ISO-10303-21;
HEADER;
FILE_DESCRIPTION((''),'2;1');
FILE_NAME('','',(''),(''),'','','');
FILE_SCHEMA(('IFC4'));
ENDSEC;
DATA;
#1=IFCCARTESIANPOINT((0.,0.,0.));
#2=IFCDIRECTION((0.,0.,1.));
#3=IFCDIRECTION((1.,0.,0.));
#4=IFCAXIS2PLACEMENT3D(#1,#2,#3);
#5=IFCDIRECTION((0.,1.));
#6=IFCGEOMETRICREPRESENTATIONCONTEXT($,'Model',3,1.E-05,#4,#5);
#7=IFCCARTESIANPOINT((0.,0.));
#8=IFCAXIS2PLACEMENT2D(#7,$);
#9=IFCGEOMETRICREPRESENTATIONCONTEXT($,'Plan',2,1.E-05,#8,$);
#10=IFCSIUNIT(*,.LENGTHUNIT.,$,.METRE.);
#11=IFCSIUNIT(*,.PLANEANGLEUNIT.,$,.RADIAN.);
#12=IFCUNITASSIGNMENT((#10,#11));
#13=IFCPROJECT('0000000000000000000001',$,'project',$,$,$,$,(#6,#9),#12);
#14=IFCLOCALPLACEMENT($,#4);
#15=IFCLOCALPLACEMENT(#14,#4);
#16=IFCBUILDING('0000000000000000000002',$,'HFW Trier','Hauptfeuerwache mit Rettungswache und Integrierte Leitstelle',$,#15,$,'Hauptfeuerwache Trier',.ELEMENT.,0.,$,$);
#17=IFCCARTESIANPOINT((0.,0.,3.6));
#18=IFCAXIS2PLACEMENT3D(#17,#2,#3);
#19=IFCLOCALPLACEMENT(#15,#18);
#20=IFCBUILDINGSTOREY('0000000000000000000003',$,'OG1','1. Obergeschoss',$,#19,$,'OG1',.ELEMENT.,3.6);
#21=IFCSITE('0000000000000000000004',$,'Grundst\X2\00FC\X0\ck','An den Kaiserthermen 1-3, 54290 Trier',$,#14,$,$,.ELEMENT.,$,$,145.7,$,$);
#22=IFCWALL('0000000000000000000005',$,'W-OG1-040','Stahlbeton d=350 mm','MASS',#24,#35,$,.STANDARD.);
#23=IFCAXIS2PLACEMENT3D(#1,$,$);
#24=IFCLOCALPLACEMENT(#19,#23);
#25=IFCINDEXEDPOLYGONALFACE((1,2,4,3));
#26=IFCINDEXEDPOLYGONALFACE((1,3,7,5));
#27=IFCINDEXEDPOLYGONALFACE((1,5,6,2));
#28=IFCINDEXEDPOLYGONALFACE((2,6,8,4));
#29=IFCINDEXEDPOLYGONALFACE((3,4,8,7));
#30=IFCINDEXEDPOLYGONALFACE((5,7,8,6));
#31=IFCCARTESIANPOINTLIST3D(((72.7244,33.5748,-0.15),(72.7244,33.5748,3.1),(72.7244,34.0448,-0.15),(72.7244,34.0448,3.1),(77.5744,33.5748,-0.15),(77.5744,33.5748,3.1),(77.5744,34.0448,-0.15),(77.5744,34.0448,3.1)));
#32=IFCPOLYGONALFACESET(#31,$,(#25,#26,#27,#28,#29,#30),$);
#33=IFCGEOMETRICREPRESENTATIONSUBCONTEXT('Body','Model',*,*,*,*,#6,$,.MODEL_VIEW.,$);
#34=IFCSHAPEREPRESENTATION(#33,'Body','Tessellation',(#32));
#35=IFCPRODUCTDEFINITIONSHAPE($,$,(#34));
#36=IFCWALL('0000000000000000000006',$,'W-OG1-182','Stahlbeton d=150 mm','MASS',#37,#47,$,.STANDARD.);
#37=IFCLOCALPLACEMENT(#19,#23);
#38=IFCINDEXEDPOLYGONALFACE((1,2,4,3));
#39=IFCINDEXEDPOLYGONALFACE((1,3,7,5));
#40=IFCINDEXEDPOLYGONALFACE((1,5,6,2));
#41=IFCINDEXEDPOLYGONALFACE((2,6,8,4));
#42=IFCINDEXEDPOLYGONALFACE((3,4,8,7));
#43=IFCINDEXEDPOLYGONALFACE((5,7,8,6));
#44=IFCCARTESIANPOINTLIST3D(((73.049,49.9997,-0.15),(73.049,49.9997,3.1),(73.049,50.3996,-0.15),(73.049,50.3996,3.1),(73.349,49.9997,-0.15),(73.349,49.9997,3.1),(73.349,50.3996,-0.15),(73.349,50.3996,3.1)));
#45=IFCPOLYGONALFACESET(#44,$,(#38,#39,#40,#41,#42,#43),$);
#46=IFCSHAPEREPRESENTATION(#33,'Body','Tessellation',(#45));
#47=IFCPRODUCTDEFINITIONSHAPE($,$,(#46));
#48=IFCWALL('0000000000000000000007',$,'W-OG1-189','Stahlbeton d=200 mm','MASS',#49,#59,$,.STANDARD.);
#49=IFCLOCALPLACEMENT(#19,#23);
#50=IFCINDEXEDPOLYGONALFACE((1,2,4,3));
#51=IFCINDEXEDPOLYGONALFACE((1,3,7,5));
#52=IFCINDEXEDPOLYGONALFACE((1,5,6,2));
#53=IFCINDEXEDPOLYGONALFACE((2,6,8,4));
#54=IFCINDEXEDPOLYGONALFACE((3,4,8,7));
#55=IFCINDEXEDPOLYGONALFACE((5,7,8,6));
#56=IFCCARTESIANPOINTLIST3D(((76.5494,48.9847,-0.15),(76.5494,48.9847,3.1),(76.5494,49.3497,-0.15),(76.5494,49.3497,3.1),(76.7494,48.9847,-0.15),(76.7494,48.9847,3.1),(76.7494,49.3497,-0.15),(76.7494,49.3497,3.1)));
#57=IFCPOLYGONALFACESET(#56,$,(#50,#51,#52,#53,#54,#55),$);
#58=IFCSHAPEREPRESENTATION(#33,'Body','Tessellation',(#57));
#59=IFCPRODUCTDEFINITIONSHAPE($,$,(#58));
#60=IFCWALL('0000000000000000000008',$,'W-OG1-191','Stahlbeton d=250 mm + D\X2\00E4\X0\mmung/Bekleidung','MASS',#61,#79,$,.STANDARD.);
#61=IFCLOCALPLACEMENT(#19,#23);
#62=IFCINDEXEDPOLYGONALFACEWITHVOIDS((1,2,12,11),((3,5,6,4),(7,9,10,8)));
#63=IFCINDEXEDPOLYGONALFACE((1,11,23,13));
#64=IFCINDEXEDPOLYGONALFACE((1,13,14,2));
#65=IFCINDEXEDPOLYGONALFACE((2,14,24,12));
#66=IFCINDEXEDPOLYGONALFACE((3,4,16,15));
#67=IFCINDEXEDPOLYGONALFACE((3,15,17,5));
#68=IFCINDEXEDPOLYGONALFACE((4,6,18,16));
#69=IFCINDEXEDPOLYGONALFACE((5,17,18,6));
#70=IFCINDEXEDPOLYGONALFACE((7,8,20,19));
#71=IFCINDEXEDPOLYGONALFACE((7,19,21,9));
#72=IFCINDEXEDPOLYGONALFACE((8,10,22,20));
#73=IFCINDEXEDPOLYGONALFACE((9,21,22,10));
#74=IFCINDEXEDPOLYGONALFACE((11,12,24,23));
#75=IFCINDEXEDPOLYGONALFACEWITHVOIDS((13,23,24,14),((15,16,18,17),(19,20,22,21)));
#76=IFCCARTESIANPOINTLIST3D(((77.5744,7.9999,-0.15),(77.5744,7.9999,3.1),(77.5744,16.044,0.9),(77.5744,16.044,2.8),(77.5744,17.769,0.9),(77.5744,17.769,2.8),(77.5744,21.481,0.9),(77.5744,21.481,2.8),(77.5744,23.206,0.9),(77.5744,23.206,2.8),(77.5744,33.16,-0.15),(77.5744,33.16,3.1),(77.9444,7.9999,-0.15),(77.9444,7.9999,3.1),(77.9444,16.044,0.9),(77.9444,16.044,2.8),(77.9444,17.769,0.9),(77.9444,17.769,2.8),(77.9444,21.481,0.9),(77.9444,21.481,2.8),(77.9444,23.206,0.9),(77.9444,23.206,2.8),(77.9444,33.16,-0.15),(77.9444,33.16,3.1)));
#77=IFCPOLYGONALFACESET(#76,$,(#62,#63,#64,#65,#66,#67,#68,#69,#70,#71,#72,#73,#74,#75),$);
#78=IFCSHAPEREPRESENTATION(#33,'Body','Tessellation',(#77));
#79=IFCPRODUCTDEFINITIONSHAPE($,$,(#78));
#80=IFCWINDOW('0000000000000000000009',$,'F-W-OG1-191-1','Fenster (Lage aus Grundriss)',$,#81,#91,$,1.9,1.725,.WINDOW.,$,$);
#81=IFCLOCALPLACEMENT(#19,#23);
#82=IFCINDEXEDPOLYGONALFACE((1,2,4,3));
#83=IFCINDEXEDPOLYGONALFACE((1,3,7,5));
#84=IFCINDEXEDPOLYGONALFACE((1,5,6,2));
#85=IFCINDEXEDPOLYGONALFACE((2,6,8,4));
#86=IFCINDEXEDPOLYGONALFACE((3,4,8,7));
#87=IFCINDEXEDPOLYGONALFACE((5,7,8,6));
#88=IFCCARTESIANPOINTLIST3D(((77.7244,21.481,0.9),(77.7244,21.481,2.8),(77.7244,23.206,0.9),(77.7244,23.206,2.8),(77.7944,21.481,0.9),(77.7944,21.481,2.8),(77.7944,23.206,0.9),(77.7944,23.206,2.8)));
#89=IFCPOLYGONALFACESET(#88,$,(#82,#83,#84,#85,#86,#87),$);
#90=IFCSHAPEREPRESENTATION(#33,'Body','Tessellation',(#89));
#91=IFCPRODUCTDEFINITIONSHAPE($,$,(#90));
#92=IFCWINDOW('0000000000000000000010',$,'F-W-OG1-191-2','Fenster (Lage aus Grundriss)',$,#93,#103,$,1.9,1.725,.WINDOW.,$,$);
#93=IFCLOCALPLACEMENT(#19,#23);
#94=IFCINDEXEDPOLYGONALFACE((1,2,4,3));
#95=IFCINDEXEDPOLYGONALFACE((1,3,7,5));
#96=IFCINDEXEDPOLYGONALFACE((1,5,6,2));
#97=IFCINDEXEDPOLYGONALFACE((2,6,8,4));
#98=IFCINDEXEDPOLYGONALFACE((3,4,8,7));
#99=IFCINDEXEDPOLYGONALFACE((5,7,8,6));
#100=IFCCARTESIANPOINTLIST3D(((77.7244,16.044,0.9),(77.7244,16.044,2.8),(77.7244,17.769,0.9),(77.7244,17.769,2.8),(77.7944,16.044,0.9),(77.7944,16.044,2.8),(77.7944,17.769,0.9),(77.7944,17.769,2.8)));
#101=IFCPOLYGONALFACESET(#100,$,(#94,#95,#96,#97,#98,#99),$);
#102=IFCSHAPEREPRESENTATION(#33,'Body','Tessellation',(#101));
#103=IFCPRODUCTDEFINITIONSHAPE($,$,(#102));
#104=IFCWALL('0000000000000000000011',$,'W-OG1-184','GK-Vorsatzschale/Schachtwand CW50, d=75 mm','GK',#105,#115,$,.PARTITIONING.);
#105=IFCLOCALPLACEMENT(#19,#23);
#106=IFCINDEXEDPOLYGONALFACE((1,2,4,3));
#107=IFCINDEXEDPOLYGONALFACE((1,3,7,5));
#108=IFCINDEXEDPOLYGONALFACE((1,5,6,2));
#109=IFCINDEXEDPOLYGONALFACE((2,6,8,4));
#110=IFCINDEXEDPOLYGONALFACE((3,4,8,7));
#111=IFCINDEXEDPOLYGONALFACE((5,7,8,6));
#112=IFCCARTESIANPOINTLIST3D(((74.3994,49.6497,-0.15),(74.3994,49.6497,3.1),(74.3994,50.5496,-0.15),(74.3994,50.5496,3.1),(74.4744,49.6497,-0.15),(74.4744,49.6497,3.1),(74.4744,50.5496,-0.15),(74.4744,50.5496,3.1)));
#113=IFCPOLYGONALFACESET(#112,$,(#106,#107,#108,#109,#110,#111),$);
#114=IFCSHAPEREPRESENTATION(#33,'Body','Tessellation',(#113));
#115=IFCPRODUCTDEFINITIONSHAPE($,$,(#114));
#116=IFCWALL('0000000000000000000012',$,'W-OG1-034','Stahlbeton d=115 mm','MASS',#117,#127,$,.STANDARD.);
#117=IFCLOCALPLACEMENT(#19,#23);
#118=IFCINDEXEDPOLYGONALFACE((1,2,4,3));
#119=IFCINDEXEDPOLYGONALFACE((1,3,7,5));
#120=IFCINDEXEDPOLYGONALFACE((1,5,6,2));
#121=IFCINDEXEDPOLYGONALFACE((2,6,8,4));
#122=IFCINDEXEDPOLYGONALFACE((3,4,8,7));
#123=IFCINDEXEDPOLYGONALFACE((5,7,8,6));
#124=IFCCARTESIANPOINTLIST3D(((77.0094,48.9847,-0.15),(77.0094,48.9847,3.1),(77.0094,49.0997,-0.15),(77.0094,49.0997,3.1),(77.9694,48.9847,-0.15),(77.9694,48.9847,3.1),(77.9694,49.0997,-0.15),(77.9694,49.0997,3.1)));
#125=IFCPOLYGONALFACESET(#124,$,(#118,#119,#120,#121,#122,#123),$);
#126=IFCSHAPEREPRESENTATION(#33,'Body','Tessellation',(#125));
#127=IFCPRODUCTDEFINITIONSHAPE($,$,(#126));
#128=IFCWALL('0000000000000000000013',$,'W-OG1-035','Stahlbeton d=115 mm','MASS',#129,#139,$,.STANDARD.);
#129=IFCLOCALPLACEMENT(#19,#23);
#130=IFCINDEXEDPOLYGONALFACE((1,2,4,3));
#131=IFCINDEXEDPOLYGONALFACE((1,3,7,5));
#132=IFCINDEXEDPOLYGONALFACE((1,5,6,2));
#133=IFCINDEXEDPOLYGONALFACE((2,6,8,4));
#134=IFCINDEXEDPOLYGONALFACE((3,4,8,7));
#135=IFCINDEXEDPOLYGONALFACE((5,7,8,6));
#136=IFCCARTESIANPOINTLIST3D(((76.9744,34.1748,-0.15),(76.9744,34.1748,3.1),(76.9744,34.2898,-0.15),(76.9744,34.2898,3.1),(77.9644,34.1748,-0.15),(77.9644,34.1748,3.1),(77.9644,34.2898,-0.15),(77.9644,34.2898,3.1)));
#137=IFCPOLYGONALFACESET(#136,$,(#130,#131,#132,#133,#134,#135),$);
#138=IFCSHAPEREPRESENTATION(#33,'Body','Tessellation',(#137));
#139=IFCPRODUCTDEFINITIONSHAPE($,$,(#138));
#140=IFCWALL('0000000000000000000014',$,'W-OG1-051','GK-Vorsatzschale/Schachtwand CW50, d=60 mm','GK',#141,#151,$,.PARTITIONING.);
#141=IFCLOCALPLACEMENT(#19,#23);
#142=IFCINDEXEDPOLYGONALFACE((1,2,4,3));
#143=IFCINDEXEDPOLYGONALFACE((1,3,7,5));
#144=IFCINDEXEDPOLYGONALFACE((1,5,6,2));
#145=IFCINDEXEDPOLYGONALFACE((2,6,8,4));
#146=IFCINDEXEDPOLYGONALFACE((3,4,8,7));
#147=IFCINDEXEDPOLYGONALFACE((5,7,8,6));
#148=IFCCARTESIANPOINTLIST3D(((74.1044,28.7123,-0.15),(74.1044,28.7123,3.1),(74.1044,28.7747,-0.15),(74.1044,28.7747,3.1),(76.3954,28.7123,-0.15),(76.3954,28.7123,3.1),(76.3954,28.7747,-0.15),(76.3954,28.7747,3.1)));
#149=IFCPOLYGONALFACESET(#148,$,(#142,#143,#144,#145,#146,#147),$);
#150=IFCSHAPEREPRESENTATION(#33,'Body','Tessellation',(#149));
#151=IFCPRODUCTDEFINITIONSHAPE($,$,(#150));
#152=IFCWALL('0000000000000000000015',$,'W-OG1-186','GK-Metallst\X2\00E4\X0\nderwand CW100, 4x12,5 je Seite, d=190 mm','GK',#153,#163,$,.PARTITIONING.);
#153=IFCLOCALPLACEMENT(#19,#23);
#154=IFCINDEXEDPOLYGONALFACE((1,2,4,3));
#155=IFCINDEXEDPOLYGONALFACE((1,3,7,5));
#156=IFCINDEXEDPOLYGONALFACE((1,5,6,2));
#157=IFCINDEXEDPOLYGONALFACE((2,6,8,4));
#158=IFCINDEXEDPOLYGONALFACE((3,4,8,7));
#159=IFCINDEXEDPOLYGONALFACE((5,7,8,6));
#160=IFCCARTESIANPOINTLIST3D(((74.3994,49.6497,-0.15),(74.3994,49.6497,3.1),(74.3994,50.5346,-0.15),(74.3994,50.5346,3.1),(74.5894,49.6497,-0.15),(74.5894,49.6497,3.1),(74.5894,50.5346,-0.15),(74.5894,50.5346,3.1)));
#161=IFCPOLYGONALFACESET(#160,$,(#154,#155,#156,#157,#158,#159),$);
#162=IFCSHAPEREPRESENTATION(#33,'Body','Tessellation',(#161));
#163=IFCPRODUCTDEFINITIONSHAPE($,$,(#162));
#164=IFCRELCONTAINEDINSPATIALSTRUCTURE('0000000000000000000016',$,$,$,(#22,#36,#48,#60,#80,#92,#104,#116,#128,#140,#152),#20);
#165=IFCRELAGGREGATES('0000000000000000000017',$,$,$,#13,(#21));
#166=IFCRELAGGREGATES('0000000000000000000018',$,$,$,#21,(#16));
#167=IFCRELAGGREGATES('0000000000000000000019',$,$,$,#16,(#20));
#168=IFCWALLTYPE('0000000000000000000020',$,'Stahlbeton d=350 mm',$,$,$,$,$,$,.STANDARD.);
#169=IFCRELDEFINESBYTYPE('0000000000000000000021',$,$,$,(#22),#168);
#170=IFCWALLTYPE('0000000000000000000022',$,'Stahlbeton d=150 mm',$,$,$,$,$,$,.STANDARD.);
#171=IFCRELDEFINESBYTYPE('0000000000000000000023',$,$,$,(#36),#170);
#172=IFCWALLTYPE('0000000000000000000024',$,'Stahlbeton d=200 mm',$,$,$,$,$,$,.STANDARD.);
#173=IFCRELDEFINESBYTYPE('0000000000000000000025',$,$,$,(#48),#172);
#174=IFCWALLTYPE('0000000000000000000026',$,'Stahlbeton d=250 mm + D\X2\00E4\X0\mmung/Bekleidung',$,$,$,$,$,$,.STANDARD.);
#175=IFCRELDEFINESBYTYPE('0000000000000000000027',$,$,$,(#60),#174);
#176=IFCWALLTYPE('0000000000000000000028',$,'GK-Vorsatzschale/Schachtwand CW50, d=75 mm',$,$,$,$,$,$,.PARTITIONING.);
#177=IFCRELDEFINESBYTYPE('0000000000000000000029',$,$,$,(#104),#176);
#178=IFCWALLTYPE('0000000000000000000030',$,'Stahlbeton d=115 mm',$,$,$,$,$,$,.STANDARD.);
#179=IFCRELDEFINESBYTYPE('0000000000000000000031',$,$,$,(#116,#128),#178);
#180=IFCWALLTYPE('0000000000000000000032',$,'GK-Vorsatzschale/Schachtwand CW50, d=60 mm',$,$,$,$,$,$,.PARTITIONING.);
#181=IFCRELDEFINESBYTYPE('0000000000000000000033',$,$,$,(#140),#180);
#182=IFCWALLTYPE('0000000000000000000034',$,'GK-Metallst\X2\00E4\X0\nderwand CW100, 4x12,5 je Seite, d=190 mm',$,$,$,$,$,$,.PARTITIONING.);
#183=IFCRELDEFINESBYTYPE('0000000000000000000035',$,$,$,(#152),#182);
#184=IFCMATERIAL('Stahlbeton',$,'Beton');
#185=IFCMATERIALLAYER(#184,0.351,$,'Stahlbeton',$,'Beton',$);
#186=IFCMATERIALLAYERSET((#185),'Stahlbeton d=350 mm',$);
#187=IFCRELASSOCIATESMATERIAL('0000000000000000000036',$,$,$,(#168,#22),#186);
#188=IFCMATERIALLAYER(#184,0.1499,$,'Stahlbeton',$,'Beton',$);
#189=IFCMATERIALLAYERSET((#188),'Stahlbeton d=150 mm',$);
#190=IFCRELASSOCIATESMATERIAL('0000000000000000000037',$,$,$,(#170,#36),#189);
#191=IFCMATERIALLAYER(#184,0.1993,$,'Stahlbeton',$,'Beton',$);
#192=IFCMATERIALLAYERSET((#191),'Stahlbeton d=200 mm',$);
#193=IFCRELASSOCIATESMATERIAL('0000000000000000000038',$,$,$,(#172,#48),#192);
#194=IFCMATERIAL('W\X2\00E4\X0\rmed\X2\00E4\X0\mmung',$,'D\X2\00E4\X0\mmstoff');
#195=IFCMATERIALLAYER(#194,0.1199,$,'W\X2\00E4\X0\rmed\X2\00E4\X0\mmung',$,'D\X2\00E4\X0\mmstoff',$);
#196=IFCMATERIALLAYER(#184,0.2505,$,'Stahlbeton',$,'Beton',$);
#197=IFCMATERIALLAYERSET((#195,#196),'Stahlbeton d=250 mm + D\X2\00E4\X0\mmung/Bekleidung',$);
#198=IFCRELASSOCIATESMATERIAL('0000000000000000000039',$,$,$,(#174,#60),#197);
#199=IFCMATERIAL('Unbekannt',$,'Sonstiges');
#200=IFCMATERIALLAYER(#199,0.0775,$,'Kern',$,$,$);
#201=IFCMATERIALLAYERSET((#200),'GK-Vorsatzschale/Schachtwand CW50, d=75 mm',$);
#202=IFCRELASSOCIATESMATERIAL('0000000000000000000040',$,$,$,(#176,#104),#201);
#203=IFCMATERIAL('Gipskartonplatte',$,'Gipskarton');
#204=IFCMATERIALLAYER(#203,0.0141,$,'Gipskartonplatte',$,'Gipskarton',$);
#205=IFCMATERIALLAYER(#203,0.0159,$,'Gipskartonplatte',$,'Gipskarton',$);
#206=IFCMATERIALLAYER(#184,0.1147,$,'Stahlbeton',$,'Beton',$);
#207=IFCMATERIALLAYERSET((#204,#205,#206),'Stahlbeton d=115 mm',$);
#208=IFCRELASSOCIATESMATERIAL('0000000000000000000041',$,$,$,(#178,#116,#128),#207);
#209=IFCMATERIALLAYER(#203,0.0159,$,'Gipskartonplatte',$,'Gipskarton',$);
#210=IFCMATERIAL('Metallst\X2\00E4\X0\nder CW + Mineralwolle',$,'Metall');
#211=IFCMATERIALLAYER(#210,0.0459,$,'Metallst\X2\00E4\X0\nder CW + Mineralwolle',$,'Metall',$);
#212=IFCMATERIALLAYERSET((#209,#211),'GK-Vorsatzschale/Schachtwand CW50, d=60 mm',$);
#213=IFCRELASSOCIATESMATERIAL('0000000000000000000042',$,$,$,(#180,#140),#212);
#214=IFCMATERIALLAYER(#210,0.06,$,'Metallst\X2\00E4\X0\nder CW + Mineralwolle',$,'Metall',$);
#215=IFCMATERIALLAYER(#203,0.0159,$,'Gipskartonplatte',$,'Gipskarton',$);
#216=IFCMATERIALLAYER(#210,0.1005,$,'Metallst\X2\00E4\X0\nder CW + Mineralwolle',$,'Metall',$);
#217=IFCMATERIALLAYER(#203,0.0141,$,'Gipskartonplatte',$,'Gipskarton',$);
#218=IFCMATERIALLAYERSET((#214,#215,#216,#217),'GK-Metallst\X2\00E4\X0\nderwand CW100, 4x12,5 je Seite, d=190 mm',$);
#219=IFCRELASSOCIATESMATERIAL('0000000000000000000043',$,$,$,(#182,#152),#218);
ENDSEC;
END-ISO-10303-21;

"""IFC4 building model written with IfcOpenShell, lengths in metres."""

from ifc_helpers import new_model, si_unit, direction, frame, frame_2d, origin_with_axes, origin_2d, place, context, subcontext, project, spatial, rectangle, extrude, material, layer, layer_set, layer_usage, type_object, element, fill, save


model = new_model("IFC4")

# Units and contexts
model_context = context("Model", 3, precision=1e-05, world=origin_with_axes(), true_north=direction((0.0, 1.0)))
plan_context = context("Plan", 2, precision=1e-05, world=origin_2d())
body_context = subcontext(model_context, "Body", "Model", "MODEL_VIEW")
ifc_project = project(units=[si_unit("LENGTHUNIT", "METRE"), si_unit("PLANEANGLEUNIT", "RADIAN")], contexts=[model_context, plan_context])

# Site, building, storey
site_placement = place(None, origin_with_axes())
site = spatial("IfcSite", under=ifc_project, at=site_placement, Name="Grundstück", Description="An den Kaiserthermen 1-3, 54290 Trier", CompositionType="ELEMENT", RefElevation=145.7)
building_placement = place(site_placement, origin_with_axes())
building = spatial("IfcBuilding", under=site, at=building_placement, Name="HFW Trier", Description="Hauptfeuerwache mit Rettungswache und Integrierte Leitstelle", LongName="Hauptfeuerwache Trier", CompositionType="ELEMENT", ElevationOfRefHeight=0.0)
storey_placement = place(building_placement, frame((0.0, 0.0, 3.6), z_axis=(0.0, 0.0, 1.0), x_axis=(1.0, 0.0, 0.0)))
storey = spatial("IfcBuildingStorey", under=building, at=storey_placement, Name="OG1", Description="1. Obergeschoss", LongName="OG1", CompositionType="ELEMENT", Elevation=3.6)

# Shared definitions
ifc_material_1 = material(Name="Stahlbeton", Category="Beton")

# Shared definitions
ifc_material_2 = material(Name="Gipskartonplatte", Category="Gipskarton")
ifc_material_3 = material(Name="Metallständer CW + Mineralwolle", Category="Metall")

# Walls
ifc_layer_1 = layer(ifc_material_1, 0.351, Name="Stahlbeton", Category="Beton")
ifc_layer_set_1 = layer_set([ifc_layer_1], Name="Stahlbeton d=350 mm")
ifc_layer_usage_1 = layer_usage(ifc_layer_set_1, "AXIS2", "POSITIVE", -0.235)
wall_type_1 = type_object("IfcWallType", Name="Stahlbeton d=350 mm", PredefinedType="STANDARD", material=ifc_layer_set_1)
wall_1_placement = place(storey_placement, frame((72.7244, 33.8098, -0.15), z_axis=(0.0, 0.0, 1.0), x_axis=(1.0, 0.0, 0.0)))
element("IfcWall", 1, at=wall_1_placement, inside=storey, type_object=wall_type_1, material=ifc_layer_usage_1, Name="W-OG1-040", Description="Stahlbeton d=350 mm", ObjectType="MASS", PredefinedType="STANDARD", context=body_context, shape_type="SweptSolid", body=[
    extrude(rectangle(XDim=4.85, YDim=0.47, at=frame_2d((2.425, 0.0))), origin_with_axes(), (0.0, 0.0, 1.0), 3.25),
])
ifc_layer_2 = layer(ifc_material_1, 0.1499, Name="Stahlbeton", Category="Beton")
ifc_layer_set_2 = layer_set([ifc_layer_2], Name="Stahlbeton d=150 mm")
ifc_layer_usage_2 = layer_usage(ifc_layer_set_2, "AXIS2", "POSITIVE", -0.15)
wall_type_2 = type_object("IfcWallType", Name="Stahlbeton d=150 mm", PredefinedType="STANDARD", material=ifc_layer_set_2)
wall_2_placement = place(storey_placement, frame((73.199, 50.3996, -0.15), z_axis=(0.0, 0.0, 1.0), x_axis=(0.0, -1.0, 0.0)))
element("IfcWall", 2, at=wall_2_placement, inside=storey, type_object=wall_type_2, material=ifc_layer_usage_2, Name="W-OG1-182", Description="Stahlbeton d=150 mm", ObjectType="MASS", PredefinedType="STANDARD", context=body_context, shape_type="SweptSolid", body=[
    extrude(rectangle(XDim=0.3999, YDim=0.3, at=frame_2d((0.2, 0.0))), origin_with_axes(), (0.0, 0.0, 1.0), 3.25),
])
ifc_layer_3 = layer(ifc_material_1, 0.1993, Name="Stahlbeton", Category="Beton")
ifc_layer_set_3 = layer_set([ifc_layer_3], Name="Stahlbeton d=200 mm")
ifc_layer_usage_3 = layer_usage(ifc_layer_set_3, "AXIS2", "POSITIVE", -0.1)
wall_type_3 = type_object("IfcWallType", Name="Stahlbeton d=200 mm", PredefinedType="STANDARD", material=ifc_layer_set_3)
wall_3_placement = place(storey_placement, frame((76.6494, 49.3497, -0.15), z_axis=(0.0, 0.0, 1.0), x_axis=(0.0, -1.0, 0.0)))
element("IfcWall", 3, at=wall_3_placement, inside=storey, type_object=wall_type_3, material=ifc_layer_usage_3, Name="W-OG1-189", Description="Stahlbeton d=200 mm", ObjectType="MASS", PredefinedType="STANDARD", context=body_context, shape_type="SweptSolid", body=[
    extrude(rectangle(XDim=0.365, YDim=0.2, at=frame_2d((0.1825, 0.0))), origin_with_axes(), (0.0, 0.0, 1.0), 3.25),
])

# Wall, openings, windows
ifc_material_4 = material(Name="Wärmedämmung", Category="Dämmstoff")
ifc_layer_4 = layer(ifc_material_4, 0.1199, Name="Wärmedämmung", Category="Dämmstoff")
ifc_layer_5 = layer(ifc_material_1, 0.2505, Name="Stahlbeton", Category="Beton")
ifc_layer_set_4 = layer_set([ifc_layer_4, ifc_layer_5], Name="Stahlbeton d=250 mm + Dämmung/Bekleidung")
ifc_layer_usage_4 = layer_usage(ifc_layer_set_4, "AXIS2", "POSITIVE", -0.185)
wall_type_4 = type_object("IfcWallType", Name="Stahlbeton d=250 mm + Dämmung/Bekleidung", PredefinedType="STANDARD", material=ifc_layer_set_4)
wall_4_placement = place(storey_placement, frame((77.7594, 33.16, -0.15), z_axis=(0.0, 0.0, 1.0), x_axis=(0.0, -1.0, 0.0)))
wall_4 = element("IfcWall", 4, at=wall_4_placement, inside=storey, type_object=wall_type_4, material=ifc_layer_usage_4, Name="W-OG1-191", Description="Stahlbeton d=250 mm + Dämmung/Bekleidung", ObjectType="MASS", PredefinedType="STANDARD", context=body_context, shape_type="SweptSolid", body=[
    extrude(rectangle(XDim=25.1601, YDim=0.37, at=frame_2d((12.58, 0.0))), origin_with_axes(), (0.0, 0.0, 1.0), 3.25),
])
opening_1_placement = place(wall_4_placement, frame((9.954, 0.0, 0.0), z_axis=(0.0, 0.0, 1.0), x_axis=(1.0, 0.0, 0.0)))
opening_1 = element("IfcOpeningElement", 5, at=opening_1_placement, cuts=wall_4, PredefinedType="OPENING", context=body_context, shape_type="SweptSolid", body=[
    extrude(rectangle(XDim=1.725, YDim=0.47, at=frame_2d((0.8625, 0.0))), frame((0.0, 0.0, 1.05), z_axis=(0.0, 0.0, 1.0), x_axis=(1.0, 0.0, 0.0)), (0.0, 0.0, 1.0), 1.9),
])
opening_2_placement = place(wall_4_placement, frame((15.391, 0.0, 0.0), z_axis=(0.0, 0.0, 1.0), x_axis=(1.0, 0.0, 0.0)))
opening_2 = element("IfcOpeningElement", 6, at=opening_2_placement, cuts=wall_4, PredefinedType="OPENING", context=body_context, shape_type="SweptSolid", body=[
    extrude(rectangle(XDim=1.725, YDim=0.47, at=frame_2d((0.8625, 0.0))), frame((0.0, 0.0, 1.05), z_axis=(0.0, 0.0, 1.0), x_axis=(1.0, 0.0, 0.0)), (0.0, 0.0, 1.0), 1.9),
])
window_1_placement = place(wall_4_placement, frame((9.954, 0.0, 0.0), z_axis=(0.0, 0.0, 1.0), x_axis=(1.0, 0.0, 0.0)))
window_1 = element("IfcWindow", 7, at=window_1_placement, inside=storey, Name="F-W-OG1-191-1", Description="Fenster (Lage aus Grundriss)", OverallHeight=1.9, OverallWidth=1.725, PredefinedType="WINDOW", context=body_context, shape_type="SweptSolid", body=[
    extrude(rectangle(XDim=1.725, YDim=0.07, at=frame_2d((0.8625, 0.0))), frame((0.0, 0.0, 1.05), z_axis=(0.0, 0.0, 1.0), x_axis=(1.0, 0.0, 0.0)), (0.0, 0.0, 1.0), 1.9),
])
fill(opening_1, window_1)
window_2_placement = place(wall_4_placement, frame((15.391, 0.0, 0.0), z_axis=(0.0, 0.0, 1.0), x_axis=(1.0, 0.0, 0.0)))
window_2 = element("IfcWindow", 8, at=window_2_placement, inside=storey, Name="F-W-OG1-191-2", Description="Fenster (Lage aus Grundriss)", OverallHeight=1.9, OverallWidth=1.725, PredefinedType="WINDOW", context=body_context, shape_type="SweptSolid", body=[
    extrude(rectangle(XDim=1.725, YDim=0.07, at=frame_2d((0.8625, 0.0))), frame((0.0, 0.0, 1.05), z_axis=(0.0, 0.0, 1.0), x_axis=(1.0, 0.0, 0.0)), (0.0, 0.0, 1.0), 1.9),
])
fill(opening_2, window_2)

# Walls
ifc_material_5 = material(Name="Unbekannt", Category="Sonstiges")
ifc_layer_6 = layer(ifc_material_5, 0.0775, Name="Kern")
ifc_layer_set_5 = layer_set([ifc_layer_6], Name="GK-Vorsatzschale/Schachtwand CW50, d=75 mm")
ifc_layer_usage_5 = layer_usage(ifc_layer_set_5, "AXIS2", "POSITIVE", -0.0375)
wall_type_5 = type_object("IfcWallType", Name="GK-Vorsatzschale/Schachtwand CW50, d=75 mm", PredefinedType="PARTITIONING", material=ifc_layer_set_5)
wall_5_placement = place(storey_placement, frame((74.4369, 50.5496, -0.15), z_axis=(0.0, 0.0, 1.0), x_axis=(0.0, -1.0, 0.0)))
element("IfcWall", 9, at=wall_5_placement, inside=storey, type_object=wall_type_5, material=ifc_layer_usage_5, Name="W-OG1-184", Description="GK-Vorsatzschale/Schachtwand CW50, d=75 mm", ObjectType="GK", PredefinedType="PARTITIONING", context=body_context, shape_type="SweptSolid", body=[
    extrude(rectangle(XDim=0.8999, YDim=0.075, at=frame_2d((0.4499, 0.0))), origin_with_axes(), (0.0, 0.0, 1.0), 3.25),
])
ifc_layer_7 = layer(ifc_material_2, 0.0141, Name="Gipskartonplatte", Category="Gipskarton")
ifc_layer_8 = layer(ifc_material_2, 0.0159, Name="Gipskartonplatte", Category="Gipskarton")
ifc_layer_9 = layer(ifc_material_1, 0.1147, Name="Stahlbeton", Category="Beton")
ifc_layer_set_6 = layer_set([ifc_layer_7, ifc_layer_8, ifc_layer_9], Name="Stahlbeton d=115 mm")
ifc_layer_usage_6 = layer_usage(ifc_layer_set_6, "AXIS2", "POSITIVE", -0.0575)
wall_type_6 = type_object("IfcWallType", Name="Stahlbeton d=115 mm", PredefinedType="STANDARD", material=ifc_layer_set_6)
wall_6_placement = place(storey_placement, frame((77.0094, 49.0422, -0.15), z_axis=(0.0, 0.0, 1.0), x_axis=(1.0, 0.0, 0.0)))
element("IfcWall", 10, at=wall_6_placement, inside=storey, type_object=wall_type_6, material=ifc_layer_usage_6, Name="W-OG1-034", Description="Stahlbeton d=115 mm", ObjectType="MASS", PredefinedType="STANDARD", context=body_context, shape_type="SweptSolid", body=[
    extrude(rectangle(XDim=0.96, YDim=0.115, at=frame_2d((0.48, 0.0))), origin_with_axes(), (0.0, 0.0, 1.0), 3.25),
])
ifc_layer_usage_7 = layer_usage(ifc_layer_set_6, "AXIS2", "POSITIVE", -0.0575)
wall_7_placement = place(storey_placement, frame((76.9744, 34.2323, -0.15), z_axis=(0.0, 0.0, 1.0), x_axis=(1.0, 0.0, 0.0)))
element("IfcWall", 11, at=wall_7_placement, inside=storey, type_object=wall_type_6, material=ifc_layer_usage_7, Name="W-OG1-035", Description="Stahlbeton d=115 mm", ObjectType="MASS", PredefinedType="STANDARD", context=body_context, shape_type="SweptSolid", body=[
    extrude(rectangle(XDim=0.99, YDim=0.115, at=frame_2d((0.495, 0.0))), origin_with_axes(), (0.0, 0.0, 1.0), 3.25),
])
ifc_layer_10 = layer(ifc_material_2, 0.0159, Name="Gipskartonplatte", Category="Gipskarton")
ifc_layer_11 = layer(ifc_material_3, 0.0459, Name="Metallständer CW + Mineralwolle", Category="Metall")
ifc_layer_set_7 = layer_set([ifc_layer_10, ifc_layer_11], Name="GK-Vorsatzschale/Schachtwand CW50, d=60 mm")
ifc_layer_usage_8 = layer_usage(ifc_layer_set_7, "AXIS2", "POSITIVE", -0.0312)
wall_type_7 = type_object("IfcWallType", Name="GK-Vorsatzschale/Schachtwand CW50, d=60 mm", PredefinedType="PARTITIONING", material=ifc_layer_set_7)
wall_8_placement = place(storey_placement, frame((74.1044, 28.7435, -0.15), z_axis=(0.0, 0.0, 1.0), x_axis=(1.0, 0.0, 0.0)))
element("IfcWall", 12, at=wall_8_placement, inside=storey, type_object=wall_type_7, material=ifc_layer_usage_8, Name="W-OG1-051", Description="GK-Vorsatzschale/Schachtwand CW50, d=60 mm", ObjectType="GK", PredefinedType="PARTITIONING", context=body_context, shape_type="SweptSolid", body=[
    extrude(rectangle(XDim=2.291, YDim=0.0624, at=frame_2d((1.1455, 0.0))), origin_with_axes(), (0.0, 0.0, 1.0), 3.25),
])
ifc_layer_12 = layer(ifc_material_3, 0.06, Name="Metallständer CW + Mineralwolle", Category="Metall")
ifc_layer_13 = layer(ifc_material_2, 0.0159, Name="Gipskartonplatte", Category="Gipskarton")
ifc_layer_14 = layer(ifc_material_3, 0.1005, Name="Metallständer CW + Mineralwolle", Category="Metall")
ifc_layer_15 = layer(ifc_material_2, 0.0141, Name="Gipskartonplatte", Category="Gipskarton")
ifc_layer_set_8 = layer_set([ifc_layer_12, ifc_layer_13, ifc_layer_14, ifc_layer_15], Name="GK-Metallständerwand CW100, 4x12,5 je Seite, d=190 mm")
ifc_layer_usage_9 = layer_usage(ifc_layer_set_8, "AXIS2", "POSITIVE", -0.095)
wall_type_8 = type_object("IfcWallType", Name="GK-Metallständerwand CW100, 4x12,5 je Seite, d=190 mm", PredefinedType="PARTITIONING", material=ifc_layer_set_8)
wall_9_placement = place(storey_placement, frame((74.4944, 50.5346, -0.15), z_axis=(0.0, 0.0, 1.0), x_axis=(0.0, -1.0, 0.0)))
element("IfcWall", 13, at=wall_9_placement, inside=storey, type_object=wall_type_8, material=ifc_layer_usage_9, Name="W-OG1-186", Description="GK-Metallständerwand CW100, 4x12,5 je Seite, d=190 mm", ObjectType="GK", PredefinedType="PARTITIONING", context=body_context, shape_type="SweptSolid", body=[
    extrude(rectangle(XDim=0.8849, YDim=0.19, at=frame_2d((0.4424, 0.0))), origin_with_axes(), (0.0, 0.0, 1.0), 3.25),
])

save(model, "model.ifc")
